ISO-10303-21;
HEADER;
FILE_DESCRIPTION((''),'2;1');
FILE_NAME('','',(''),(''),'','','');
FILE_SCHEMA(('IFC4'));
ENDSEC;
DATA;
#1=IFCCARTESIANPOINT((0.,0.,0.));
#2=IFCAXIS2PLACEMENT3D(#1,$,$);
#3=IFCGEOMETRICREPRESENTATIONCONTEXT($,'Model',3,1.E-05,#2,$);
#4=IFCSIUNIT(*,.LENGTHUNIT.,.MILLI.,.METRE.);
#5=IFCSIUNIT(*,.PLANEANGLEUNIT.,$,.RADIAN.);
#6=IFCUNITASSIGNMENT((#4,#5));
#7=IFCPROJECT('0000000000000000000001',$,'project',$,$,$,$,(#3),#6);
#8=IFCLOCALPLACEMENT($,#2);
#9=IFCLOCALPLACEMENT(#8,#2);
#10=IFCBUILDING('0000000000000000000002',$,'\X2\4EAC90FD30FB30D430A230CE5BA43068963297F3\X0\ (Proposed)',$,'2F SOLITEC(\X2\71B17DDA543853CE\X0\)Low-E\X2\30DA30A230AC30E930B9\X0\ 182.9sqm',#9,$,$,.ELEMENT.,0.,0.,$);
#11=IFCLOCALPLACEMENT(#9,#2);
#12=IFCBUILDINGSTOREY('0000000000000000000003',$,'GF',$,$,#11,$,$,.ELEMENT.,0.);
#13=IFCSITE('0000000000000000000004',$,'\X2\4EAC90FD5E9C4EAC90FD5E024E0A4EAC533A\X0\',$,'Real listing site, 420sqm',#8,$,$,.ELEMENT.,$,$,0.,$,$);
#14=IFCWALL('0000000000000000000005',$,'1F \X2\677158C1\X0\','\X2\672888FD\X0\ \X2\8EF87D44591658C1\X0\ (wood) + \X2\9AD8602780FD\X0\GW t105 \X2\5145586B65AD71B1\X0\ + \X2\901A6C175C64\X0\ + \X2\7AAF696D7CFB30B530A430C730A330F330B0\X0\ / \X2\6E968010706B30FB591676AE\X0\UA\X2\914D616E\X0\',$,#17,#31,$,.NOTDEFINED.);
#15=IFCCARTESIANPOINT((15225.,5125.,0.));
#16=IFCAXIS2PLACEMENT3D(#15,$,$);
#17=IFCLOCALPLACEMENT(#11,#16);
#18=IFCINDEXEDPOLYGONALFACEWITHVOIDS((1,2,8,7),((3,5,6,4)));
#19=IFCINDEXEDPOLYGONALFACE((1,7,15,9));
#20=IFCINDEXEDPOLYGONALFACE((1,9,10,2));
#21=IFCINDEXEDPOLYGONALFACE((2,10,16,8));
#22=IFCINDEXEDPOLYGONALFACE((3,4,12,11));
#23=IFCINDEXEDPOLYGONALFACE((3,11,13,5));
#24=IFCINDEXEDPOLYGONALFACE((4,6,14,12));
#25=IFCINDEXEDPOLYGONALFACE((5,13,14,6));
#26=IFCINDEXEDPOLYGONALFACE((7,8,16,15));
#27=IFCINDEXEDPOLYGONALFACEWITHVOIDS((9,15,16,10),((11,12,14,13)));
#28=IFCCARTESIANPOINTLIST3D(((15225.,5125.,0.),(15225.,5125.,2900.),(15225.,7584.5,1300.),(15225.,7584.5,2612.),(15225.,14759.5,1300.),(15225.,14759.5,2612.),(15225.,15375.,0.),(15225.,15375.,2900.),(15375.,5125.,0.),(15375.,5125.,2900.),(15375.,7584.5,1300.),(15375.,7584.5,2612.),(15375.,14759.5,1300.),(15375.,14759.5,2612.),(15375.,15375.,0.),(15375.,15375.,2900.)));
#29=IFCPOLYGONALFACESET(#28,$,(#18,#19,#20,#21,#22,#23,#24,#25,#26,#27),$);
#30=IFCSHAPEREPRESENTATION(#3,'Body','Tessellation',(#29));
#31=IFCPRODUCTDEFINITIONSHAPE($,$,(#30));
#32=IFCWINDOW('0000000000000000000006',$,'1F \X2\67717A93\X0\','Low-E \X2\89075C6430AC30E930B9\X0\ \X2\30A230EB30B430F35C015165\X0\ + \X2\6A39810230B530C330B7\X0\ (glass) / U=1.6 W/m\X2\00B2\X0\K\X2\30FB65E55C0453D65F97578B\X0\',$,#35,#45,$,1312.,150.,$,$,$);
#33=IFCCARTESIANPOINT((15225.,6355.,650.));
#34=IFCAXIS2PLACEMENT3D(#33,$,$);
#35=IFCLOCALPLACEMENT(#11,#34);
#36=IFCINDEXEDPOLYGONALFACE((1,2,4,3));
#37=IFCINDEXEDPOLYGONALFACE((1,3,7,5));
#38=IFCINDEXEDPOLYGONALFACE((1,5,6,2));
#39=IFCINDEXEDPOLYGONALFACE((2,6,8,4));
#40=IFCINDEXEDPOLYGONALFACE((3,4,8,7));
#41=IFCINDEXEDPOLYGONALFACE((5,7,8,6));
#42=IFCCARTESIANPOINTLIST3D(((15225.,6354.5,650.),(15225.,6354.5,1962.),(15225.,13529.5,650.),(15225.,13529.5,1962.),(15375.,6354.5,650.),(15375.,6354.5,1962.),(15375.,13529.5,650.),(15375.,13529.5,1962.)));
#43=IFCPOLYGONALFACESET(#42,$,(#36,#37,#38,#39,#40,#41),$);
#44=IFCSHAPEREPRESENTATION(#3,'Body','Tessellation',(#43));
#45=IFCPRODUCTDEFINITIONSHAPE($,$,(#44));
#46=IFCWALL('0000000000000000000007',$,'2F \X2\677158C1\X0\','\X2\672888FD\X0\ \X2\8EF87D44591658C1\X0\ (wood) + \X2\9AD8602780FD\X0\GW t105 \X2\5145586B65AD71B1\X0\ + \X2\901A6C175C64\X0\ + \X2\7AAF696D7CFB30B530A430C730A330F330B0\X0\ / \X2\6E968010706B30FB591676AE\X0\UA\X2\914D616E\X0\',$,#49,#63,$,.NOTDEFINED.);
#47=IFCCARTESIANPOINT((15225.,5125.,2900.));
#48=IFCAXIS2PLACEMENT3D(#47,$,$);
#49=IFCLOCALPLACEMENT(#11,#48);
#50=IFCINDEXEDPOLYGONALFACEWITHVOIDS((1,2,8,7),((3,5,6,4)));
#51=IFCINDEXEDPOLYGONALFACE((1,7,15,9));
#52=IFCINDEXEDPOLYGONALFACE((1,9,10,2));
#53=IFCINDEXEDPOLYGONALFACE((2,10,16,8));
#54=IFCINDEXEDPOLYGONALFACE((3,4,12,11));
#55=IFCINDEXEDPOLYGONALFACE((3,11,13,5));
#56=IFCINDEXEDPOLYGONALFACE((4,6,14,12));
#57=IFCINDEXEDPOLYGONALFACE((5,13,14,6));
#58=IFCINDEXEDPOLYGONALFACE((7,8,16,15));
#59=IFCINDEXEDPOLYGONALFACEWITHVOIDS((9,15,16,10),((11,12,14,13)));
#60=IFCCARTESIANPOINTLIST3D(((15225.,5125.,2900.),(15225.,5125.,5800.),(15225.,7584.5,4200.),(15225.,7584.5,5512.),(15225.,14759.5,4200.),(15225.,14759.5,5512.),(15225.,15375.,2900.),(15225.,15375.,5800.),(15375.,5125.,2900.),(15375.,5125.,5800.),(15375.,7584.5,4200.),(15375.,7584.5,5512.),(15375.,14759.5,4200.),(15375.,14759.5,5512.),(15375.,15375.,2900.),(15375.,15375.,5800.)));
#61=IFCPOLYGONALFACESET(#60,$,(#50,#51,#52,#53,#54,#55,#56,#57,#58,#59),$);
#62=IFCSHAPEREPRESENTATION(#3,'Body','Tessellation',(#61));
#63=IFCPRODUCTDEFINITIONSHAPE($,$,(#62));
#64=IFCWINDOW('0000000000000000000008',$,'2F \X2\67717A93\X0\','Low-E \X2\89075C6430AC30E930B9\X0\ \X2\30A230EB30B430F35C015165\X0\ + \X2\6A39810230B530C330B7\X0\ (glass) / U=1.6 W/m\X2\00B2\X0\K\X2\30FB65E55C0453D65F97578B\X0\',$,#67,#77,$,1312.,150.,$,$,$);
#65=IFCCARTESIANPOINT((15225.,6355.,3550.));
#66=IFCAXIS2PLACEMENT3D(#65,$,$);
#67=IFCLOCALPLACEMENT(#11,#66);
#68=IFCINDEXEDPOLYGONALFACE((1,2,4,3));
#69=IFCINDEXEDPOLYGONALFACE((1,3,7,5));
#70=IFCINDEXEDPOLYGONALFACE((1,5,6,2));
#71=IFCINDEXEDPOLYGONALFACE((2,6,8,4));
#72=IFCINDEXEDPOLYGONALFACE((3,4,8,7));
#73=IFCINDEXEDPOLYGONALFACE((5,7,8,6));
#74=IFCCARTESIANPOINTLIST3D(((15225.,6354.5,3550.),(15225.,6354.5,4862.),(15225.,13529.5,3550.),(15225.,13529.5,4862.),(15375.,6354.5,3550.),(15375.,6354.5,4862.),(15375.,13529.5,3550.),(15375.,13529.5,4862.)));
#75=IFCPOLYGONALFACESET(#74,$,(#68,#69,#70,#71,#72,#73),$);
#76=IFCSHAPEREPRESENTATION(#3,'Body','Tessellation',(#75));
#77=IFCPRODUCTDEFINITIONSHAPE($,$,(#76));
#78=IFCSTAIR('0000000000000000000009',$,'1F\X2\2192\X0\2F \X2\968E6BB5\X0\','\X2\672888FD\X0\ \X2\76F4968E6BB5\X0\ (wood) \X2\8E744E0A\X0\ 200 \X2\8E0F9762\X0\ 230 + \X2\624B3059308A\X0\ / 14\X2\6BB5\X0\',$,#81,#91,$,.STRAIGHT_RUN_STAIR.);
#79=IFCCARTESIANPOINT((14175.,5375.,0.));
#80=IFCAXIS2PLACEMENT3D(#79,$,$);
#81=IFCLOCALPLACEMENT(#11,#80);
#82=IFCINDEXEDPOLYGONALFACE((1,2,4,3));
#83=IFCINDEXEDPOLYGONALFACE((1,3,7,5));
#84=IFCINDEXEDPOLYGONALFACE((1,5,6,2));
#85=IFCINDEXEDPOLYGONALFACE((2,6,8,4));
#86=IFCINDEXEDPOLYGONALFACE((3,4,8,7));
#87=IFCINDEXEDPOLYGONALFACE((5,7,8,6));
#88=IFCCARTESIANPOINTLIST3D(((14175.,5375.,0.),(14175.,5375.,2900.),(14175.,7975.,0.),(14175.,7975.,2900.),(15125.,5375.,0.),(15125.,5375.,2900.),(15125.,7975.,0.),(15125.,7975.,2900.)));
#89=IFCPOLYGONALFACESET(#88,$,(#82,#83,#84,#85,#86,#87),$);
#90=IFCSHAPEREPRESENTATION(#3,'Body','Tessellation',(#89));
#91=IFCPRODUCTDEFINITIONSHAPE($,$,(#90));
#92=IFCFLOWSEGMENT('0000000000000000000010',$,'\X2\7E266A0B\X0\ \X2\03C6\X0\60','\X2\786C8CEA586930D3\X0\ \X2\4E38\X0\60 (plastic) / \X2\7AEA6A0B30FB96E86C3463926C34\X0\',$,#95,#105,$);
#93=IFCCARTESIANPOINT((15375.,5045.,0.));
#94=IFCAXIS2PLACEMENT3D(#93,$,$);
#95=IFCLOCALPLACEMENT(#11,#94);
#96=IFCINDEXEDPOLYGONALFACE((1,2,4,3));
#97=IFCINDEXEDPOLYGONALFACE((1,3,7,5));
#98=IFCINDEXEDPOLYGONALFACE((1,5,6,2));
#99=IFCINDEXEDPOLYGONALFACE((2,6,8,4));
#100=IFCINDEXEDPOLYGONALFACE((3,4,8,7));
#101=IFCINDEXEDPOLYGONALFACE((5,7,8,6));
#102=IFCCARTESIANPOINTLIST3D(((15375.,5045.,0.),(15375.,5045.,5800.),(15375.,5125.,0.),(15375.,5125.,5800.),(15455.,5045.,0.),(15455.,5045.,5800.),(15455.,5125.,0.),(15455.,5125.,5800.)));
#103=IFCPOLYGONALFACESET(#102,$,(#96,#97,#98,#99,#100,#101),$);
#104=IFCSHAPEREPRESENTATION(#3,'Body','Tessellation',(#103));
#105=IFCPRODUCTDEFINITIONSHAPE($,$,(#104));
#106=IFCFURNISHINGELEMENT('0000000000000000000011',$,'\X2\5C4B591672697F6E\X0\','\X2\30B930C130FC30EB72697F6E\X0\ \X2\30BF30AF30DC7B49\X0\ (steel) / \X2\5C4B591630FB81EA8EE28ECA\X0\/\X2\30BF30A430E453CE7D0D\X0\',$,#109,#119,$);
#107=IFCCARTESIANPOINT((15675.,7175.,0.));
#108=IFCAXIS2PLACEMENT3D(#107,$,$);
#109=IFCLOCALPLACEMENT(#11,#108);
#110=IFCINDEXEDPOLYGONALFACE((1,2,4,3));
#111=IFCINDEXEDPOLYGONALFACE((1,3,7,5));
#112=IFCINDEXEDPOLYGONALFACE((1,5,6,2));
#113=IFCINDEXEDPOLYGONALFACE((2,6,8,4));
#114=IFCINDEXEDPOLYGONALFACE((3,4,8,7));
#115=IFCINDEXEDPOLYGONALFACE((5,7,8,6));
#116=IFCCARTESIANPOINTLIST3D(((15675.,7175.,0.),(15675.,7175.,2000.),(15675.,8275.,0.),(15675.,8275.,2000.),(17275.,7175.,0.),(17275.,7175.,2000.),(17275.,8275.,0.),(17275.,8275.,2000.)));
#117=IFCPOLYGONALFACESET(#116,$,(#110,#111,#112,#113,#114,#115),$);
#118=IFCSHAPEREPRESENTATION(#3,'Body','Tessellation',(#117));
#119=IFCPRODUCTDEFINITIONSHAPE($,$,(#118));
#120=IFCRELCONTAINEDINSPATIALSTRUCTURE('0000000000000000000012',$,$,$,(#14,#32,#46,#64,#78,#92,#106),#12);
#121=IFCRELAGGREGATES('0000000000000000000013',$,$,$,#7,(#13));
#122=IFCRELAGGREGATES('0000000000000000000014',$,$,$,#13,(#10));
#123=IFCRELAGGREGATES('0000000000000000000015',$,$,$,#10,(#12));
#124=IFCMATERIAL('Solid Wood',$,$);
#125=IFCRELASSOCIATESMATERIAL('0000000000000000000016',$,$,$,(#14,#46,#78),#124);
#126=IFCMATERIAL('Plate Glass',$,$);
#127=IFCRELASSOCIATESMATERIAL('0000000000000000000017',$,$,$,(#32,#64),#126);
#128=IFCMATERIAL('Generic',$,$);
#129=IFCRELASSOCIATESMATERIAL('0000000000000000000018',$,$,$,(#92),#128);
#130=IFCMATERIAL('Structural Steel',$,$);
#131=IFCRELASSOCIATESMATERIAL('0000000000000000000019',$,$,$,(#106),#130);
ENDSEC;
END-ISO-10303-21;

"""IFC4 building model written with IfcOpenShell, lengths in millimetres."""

from ifc_helpers import new_model, si_unit, frame, frame_2d, origin, place, context, project, spatial, rectangle, extrude, material, element, fill, save


model = new_model("IFC4")

# Units and contexts
model_context = context("Model", 3, precision=1e-05, world=origin())
ifc_project = project(units=[si_unit("LENGTHUNIT", "METRE", prefix="MILLI"), si_unit("PLANEANGLEUNIT", "RADIAN")], contexts=[model_context])

# Site, building, storey
site_placement = place(None, origin())
site = spatial("IfcSite", under=ifc_project, at=site_placement, Name="京都府京都市上京区", ObjectType="Real listing site, 420sqm", CompositionType="ELEMENT", RefElevation=0.0)
building_placement = place(site_placement, origin())
building = spatial("IfcBuilding", under=site, at=building_placement, Name="京都・ピアノ室と防音 (Proposed)", ObjectType="2F SOLITEC(熱線吸収)Low-Eペアガラス 182.9sqm", CompositionType="ELEMENT", ElevationOfRefHeight=0.0, ElevationOfTerrain=0.0)
storey_placement = place(building_placement, origin())
storey = spatial("IfcBuildingStorey", under=building, at=storey_placement, Name="GF", CompositionType="ELEMENT", Elevation=0.0)

# Shared definitions
ifc_material_1 = material(Name="Solid Wood")

# Walls, openings, windows
wall_1_placement = place(storey_placement, frame((15225.0, 5125.0, 0.0)))
wall_1 = element("IfcWall", 1, at=wall_1_placement, inside=storey, material=ifc_material_1, Name="1F 東壁", Description="木製 軸組外壁 (wood) + 高性能GW t105 充填断熱 + 通気層 + 窯業系サイディング / 準耐火・外皮UA配慮", PredefinedType="NOTDEFINED", context=model_context, shape_type="SweptSolid", body=[
    extrude(rectangle(XDim=150.0, YDim=10250.0, at=frame_2d((75.0, 5125.0))), frame((15225.0, 5125.0, 0.0)), (0.0, 0.0, 1.0), 2900.0),
])
opening_1_placement = place(storey_placement, frame((15225.0, 6355.0, 650.0)))
opening_1 = element("IfcOpeningElement", 2, at=opening_1_placement, cuts=wall_1, PredefinedType="NOTDEFINED", context=model_context, shape_type="SweptSolid", body=[
    extrude(rectangle(XDim=150.0, YDim=7175.0, at=frame_2d((75.0, 3587.0))), frame((15225.0, 6355.0, 650.0)), (0.0, 0.0, 1.0), 1312.0),
])
ifc_material_2 = material(Name="Plate Glass")
window_1_placement = place(storey_placement, frame((15225.0, 6355.0, 650.0)))
window_1 = element("IfcWindow", 3, at=window_1_placement, inside=storey, material=ifc_material_2, Name="1F 東窓", Description="Low-E 複層ガラス アルゴン封入 + 樹脂サッシ (glass) / U=1.6 W/m²K・日射取得型", OverallHeight=1312.0, OverallWidth=150.0, context=model_context, shape_type="SweptSolid", body=[
    extrude(rectangle(XDim=150.0, YDim=7175.0, at=frame_2d((75.0, 3587.0))), frame((15225.0, 6355.0, 650.0)), (0.0, 0.0, 1.0), 1312.0),
])
fill(opening_1, window_1)
wall_2_placement = place(storey_placement, frame((15225.0, 5125.0, 2900.0)))
wall_2 = element("IfcWall", 4, at=wall_2_placement, inside=storey, material=ifc_material_1, Name="2F 東壁", Description="木製 軸組外壁 (wood) + 高性能GW t105 充填断熱 + 通気層 + 窯業系サイディング / 準耐火・外皮UA配慮", PredefinedType="NOTDEFINED", context=model_context, shape_type="SweptSolid", body=[
    extrude(rectangle(XDim=150.0, YDim=10250.0, at=frame_2d((75.0, 5125.0))), frame((15225.0, 5125.0, 2900.0)), (0.0, 0.0, 1.0), 2900.0),
])
opening_2_placement = place(storey_placement, frame((15225.0, 6355.0, 3550.0)))
opening_2 = element("IfcOpeningElement", 5, at=opening_2_placement, cuts=wall_2, PredefinedType="NOTDEFINED", context=model_context, shape_type="SweptSolid", body=[
    extrude(rectangle(XDim=150.0, YDim=7175.0, at=frame_2d((75.0, 3587.0))), frame((15225.0, 6355.0, 3550.0)), (0.0, 0.0, 1.0), 1312.0),
])
window_2_placement = place(storey_placement, frame((15225.0, 6355.0, 3550.0)))
window_2 = element("IfcWindow", 6, at=window_2_placement, inside=storey, material=ifc_material_2, Name="2F 東窓", Description="Low-E 複層ガラス アルゴン封入 + 樹脂サッシ (glass) / U=1.6 W/m²K・日射取得型", OverallHeight=1312.0, OverallWidth=150.0, context=model_context, shape_type="SweptSolid", body=[
    extrude(rectangle(XDim=150.0, YDim=7175.0, at=frame_2d((75.0, 3587.0))), frame((15225.0, 6355.0, 3550.0)), (0.0, 0.0, 1.0), 1312.0),
])
fill(opening_2, window_2)

# Stair
stair_placement = place(storey_placement, frame((14175.0, 5375.0, 0.0)))
element("IfcStair", 7, at=stair_placement, inside=storey, material=ifc_material_1, Name="1F→2F 階段", Description="木製 直階段 (wood) 蹴上 200 踏面 230 + 手すり / 14段", PredefinedType="STRAIGHT_RUN_STAIR", context=model_context, shape_type="SweptSolid", body=[
    extrude(rectangle(XDim=950.0, YDim=2600.0, at=frame_2d((475.0, 1300.0))), frame((14175.0, 5375.0, 0.0)), (0.0, 0.0, 1.0), 2900.0),
])

# Flow segment
ifc_material_3 = material(Name="Generic")
flow_segment_placement = place(storey_placement, frame((15375.0, 5045.0, 0.0)))
element("IfcFlowSegment", 8, at=flow_segment_placement, inside=storey, material=ifc_material_3, Name="縦樋 φ60", Description="硬質塩ビ 丸60 (plastic) / 竪樋・雨水排水", context=model_context, shape_type="SweptSolid", body=[
    extrude(rectangle(XDim=80.0, YDim=80.0, at=frame_2d((40.0, 40.0))), frame((15375.0, 5045.0, 0.0)), (0.0, 0.0, 1.0), 5800.0),
])

# Furnishing element
ifc_material_4 = material(Name="Structural Steel")
furnishing_placement = place(storey_placement, frame((15675.0, 7175.0, 0.0)))
element("IfcFurnishingElement", 9, at=furnishing_placement, inside=storey, material=ifc_material_4, Name="屋外物置", Description="スチール物置 タクボ等 (steel) / 屋外・自転車/タイヤ収納", context=model_context, shape_type="SweptSolid", body=[
    extrude(rectangle(XDim=1600.0, YDim=1100.0, at=frame_2d((800.0, 550.0))), frame((15675.0, 7175.0, 0.0)), (0.0, 0.0, 1.0), 2000.0),
])

save(model, "model.ifc")
